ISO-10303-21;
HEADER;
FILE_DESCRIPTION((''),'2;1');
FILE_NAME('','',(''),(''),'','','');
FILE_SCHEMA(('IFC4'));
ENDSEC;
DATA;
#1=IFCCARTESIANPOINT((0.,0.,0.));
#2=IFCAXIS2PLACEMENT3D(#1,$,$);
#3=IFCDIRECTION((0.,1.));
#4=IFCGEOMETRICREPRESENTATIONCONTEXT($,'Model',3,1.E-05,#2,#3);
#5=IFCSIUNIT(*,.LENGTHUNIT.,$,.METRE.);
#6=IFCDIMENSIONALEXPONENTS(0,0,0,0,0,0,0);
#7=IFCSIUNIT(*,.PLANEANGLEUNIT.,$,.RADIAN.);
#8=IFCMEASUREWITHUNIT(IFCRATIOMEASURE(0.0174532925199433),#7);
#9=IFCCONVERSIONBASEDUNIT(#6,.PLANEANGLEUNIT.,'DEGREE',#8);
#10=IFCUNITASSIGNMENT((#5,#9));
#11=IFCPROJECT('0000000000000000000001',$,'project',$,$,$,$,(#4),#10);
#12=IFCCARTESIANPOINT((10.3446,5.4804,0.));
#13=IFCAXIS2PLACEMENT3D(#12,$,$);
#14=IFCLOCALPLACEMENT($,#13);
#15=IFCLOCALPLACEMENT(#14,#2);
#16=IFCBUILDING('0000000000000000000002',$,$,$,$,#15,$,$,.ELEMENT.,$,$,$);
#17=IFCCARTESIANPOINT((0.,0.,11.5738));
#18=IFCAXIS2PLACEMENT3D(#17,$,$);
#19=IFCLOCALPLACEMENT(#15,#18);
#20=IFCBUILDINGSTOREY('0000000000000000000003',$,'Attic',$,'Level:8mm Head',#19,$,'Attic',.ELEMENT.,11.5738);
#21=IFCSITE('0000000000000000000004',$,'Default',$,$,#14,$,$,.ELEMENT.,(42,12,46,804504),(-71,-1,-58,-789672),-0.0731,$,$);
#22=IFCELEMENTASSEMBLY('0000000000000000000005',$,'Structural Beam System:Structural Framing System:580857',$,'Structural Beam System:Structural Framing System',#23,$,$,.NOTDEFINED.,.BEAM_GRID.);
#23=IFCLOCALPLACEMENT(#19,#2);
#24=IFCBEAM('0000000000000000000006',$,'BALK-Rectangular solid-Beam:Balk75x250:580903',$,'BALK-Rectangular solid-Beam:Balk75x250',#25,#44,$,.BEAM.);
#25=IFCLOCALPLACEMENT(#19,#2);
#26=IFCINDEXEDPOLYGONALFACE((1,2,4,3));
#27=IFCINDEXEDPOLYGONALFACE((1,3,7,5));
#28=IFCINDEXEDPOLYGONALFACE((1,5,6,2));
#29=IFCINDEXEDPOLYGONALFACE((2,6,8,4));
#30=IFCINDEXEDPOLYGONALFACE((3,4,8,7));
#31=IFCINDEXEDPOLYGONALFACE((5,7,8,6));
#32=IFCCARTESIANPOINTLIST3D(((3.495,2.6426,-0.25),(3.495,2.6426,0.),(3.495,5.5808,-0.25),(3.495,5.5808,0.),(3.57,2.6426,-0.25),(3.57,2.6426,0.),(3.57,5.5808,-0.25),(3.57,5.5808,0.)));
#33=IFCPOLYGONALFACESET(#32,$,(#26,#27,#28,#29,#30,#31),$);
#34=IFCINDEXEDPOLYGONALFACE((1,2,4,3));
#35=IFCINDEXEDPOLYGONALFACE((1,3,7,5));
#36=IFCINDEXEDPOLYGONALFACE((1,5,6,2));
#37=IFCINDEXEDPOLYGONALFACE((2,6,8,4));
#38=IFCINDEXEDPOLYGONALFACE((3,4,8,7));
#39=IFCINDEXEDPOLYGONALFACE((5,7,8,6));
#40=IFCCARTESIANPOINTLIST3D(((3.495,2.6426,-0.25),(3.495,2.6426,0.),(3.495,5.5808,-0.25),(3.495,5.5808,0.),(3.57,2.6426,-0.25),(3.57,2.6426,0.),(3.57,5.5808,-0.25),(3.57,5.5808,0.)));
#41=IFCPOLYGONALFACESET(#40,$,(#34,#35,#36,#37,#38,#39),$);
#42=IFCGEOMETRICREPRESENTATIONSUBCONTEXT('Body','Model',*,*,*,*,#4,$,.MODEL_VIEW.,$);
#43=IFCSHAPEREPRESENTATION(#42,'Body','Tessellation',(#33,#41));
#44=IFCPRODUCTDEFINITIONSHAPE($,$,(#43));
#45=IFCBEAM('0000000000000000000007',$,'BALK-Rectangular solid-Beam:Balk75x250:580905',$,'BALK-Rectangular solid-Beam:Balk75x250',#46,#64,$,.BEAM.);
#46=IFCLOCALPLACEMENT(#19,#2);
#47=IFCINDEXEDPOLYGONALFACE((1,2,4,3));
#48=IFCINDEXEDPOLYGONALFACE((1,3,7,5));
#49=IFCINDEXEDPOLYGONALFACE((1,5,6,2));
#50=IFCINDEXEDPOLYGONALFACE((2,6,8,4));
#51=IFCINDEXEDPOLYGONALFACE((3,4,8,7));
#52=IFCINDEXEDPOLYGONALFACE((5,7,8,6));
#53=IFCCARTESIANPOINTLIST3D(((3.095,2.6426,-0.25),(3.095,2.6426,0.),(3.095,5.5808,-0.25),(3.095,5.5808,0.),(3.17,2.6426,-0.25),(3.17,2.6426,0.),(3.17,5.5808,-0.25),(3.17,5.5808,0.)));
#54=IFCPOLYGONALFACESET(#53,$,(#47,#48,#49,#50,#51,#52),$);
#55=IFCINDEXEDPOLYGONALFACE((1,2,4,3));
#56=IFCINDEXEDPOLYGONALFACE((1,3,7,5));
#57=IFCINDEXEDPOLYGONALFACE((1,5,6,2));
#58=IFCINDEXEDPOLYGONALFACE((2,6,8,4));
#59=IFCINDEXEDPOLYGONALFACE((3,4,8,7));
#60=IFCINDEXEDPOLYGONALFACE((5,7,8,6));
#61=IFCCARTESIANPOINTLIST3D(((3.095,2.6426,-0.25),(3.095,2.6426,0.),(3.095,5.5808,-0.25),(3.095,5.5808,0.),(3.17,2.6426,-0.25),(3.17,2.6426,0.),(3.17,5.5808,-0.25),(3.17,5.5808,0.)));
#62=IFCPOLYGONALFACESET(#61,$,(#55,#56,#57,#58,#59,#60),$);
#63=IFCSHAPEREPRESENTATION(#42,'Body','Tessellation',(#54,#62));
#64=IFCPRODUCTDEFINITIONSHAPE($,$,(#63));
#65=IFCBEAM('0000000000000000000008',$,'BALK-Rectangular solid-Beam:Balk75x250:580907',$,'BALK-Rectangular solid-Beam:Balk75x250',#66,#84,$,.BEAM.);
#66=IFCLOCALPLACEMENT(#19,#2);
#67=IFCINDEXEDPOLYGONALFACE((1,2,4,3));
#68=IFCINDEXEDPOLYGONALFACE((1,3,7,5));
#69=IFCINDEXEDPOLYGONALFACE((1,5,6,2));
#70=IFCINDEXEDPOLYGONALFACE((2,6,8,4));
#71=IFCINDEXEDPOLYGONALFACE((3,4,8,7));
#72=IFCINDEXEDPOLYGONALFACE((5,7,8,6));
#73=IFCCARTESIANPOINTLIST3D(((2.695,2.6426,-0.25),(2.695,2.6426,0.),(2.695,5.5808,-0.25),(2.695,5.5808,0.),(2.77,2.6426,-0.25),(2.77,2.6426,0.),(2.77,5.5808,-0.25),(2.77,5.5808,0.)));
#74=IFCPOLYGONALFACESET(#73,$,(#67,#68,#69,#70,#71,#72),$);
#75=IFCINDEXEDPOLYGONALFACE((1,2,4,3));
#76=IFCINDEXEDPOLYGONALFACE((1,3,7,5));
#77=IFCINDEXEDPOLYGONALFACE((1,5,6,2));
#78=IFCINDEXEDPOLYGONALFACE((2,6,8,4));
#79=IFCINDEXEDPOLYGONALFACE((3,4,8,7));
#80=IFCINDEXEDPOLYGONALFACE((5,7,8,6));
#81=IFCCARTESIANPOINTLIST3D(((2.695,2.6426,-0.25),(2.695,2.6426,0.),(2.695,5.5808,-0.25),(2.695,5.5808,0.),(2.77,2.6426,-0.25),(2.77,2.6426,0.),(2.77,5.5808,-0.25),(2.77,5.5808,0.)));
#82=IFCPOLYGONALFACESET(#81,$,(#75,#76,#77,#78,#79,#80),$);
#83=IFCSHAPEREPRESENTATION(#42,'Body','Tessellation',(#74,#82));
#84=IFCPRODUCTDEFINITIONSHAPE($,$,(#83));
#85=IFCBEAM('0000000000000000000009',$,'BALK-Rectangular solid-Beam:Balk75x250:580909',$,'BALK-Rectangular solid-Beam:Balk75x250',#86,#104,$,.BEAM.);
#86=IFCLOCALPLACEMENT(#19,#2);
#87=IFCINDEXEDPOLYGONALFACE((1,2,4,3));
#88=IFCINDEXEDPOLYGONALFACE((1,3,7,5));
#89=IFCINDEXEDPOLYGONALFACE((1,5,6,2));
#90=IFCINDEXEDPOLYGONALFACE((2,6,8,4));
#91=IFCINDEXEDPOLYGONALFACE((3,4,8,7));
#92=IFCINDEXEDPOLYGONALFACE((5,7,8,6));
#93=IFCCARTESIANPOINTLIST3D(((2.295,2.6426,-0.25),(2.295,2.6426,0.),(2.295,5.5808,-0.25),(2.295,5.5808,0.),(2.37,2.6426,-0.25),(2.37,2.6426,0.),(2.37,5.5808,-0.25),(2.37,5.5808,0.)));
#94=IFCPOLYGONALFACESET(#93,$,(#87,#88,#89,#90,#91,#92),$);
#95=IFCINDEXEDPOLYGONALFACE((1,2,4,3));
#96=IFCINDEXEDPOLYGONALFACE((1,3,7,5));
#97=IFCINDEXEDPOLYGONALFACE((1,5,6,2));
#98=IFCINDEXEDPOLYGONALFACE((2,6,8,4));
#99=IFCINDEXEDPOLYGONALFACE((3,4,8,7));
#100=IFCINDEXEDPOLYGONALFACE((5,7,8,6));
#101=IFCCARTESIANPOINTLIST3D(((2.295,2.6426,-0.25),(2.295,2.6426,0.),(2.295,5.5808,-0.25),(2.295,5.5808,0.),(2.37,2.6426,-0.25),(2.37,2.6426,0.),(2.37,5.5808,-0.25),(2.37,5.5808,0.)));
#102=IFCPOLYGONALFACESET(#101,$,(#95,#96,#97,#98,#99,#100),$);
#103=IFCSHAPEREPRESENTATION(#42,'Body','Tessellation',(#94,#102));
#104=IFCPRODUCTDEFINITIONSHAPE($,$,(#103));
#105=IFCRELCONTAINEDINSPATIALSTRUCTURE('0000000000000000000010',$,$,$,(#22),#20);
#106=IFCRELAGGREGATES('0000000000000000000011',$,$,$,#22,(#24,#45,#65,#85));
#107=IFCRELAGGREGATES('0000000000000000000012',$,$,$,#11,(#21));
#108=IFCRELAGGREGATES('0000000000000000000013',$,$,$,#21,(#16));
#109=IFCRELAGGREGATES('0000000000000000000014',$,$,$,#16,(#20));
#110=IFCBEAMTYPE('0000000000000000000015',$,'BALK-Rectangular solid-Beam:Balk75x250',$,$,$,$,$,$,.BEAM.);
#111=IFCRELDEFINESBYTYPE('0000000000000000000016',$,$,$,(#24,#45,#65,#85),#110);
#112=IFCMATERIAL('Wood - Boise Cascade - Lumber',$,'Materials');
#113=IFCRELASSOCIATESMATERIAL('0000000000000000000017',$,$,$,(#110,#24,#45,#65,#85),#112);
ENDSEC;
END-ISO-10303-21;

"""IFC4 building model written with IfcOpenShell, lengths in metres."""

from ifc_helpers import new_model, entity, si_unit, converted_unit, direction, frame, frame_2d, origin, origin_2d_with_axis, place, context, subcontext, project, spatial, rectangle, extrude, source, transform, mapped, material, material_profile, profile_set, profile_usage, type_object, type_shapes, element, aggregate, save


model = new_model("IFC4")

# Units and contexts
model_context = context("Model", 3, precision=1e-05, world=origin(), true_north=direction((0.0, 1.0)))
body_context = subcontext(model_context, "Body", "Model", "MODEL_VIEW")
ifc_project = project(units=[si_unit("LENGTHUNIT", "METRE"), converted_unit("PLANEANGLEUNIT", "DEGREE", entity("IfcRatioMeasure", 0.0174532925199433), si_unit("PLANEANGLEUNIT", "RADIAN"), dimensions=[0, 0, 0, 0, 0, 0, 0])], contexts=[model_context])

# Site, building, storey
site_placement = place(None, frame((10.3446, 5.4804, 0.0)))
site = spatial("IfcSite", under=ifc_project, at=site_placement, Name="Default", CompositionType="ELEMENT", RefLatitude=(42, 12, 46, 804504), RefLongitude=(-71, -1, -58, -789672), RefElevation=-0.0731)
building_placement = place(site_placement, origin())
building = spatial("IfcBuilding", under=site, at=building_placement, CompositionType="ELEMENT")
storey_placement = place(building_placement, frame((0.0, 0.0, 11.5738)))
storey = spatial("IfcBuildingStorey", under=building, at=storey_placement, Name="Attic", ObjectType="Level:8mm Head", LongName="Attic", CompositionType="ELEMENT", Elevation=11.5738)

# Shared definitions
ifc_material = material(Name="Wood - Boise Cascade - Lumber", Category="Materials")
ifc_material_profile = material_profile(ifc_material, rectangle(XDim=0.25, YDim=0.075, at=frame_2d((0.0, 0.0), x_axis=(1.0, 0.0))), Name="Balk75x250")
ifc_profile_set = profile_set([ifc_material_profile], Name="Balk75x250")

# Element assembly
assembly_1_placement = place(storey_placement, origin())
assembly_1 = element("IfcElementAssembly", 1, at=assembly_1_placement, inside=storey, Name="Structural Beam System:Structural Framing System:580857", ObjectType="Structural Beam System:Structural Framing System", AssemblyPlace="NOTDEFINED", PredefinedType="BEAM_GRID")

# Beams
beam_type_1 = type_object("IfcBeamType", Name="BALK-Rectangular solid-Beam:Balk75x250", PredefinedType="BEAM", material=ifc_profile_set)
shared_shape_1 = source(origin(), body_context, "Body", "SweptSolid", [
    extrude(rectangle(XDim=0.25, YDim=0.075, at=origin_2d_with_axis()), frame((-1.4566, 0.0, 0.0), z_axis=(1.0, 0.0, 0.0), x_axis=(0.0, 0.0, -1.0)), (0.0, 0.0, 1.0), 2.9382),
    extrude(rectangle(XDim=0.25, YDim=0.075, at=origin_2d_with_axis()), frame((-1.4566, 0.0, 0.0), z_axis=(1.0, 0.0, 0.0), x_axis=(0.0, 0.0, -1.0)), (0.0, 0.0, 1.0), 2.9382),
])
type_shapes(beam_type_1, [shared_shape_1])
ifc_profile_usage_1 = profile_usage(ifc_profile_set, cardinal=8)
beam_1_placement = place(assembly_1_placement, frame((3.5325, 4.1242, -0.125), z_axis=(0.0, 0.0, 1.0), x_axis=(0.0, -1.0, 0.0)))
beam_1 = element("IfcBeam", 2, at=beam_1_placement, type_object=beam_type_1, material=ifc_profile_usage_1, Name="BALK-Rectangular solid-Beam:Balk75x250:580903", ObjectType="BALK-Rectangular solid-Beam:Balk75x250", PredefinedType="BEAM", context=body_context, shape_type="MappedRepresentation", body=[
    mapped(shared_shape_1, transform((0.0, 0.0, 0.0), scale=1.0)),
])
ifc_profile_usage_2 = profile_usage(ifc_profile_set, cardinal=8)
beam_2_placement = place(assembly_1_placement, frame((3.1325, 4.1242, -0.125), z_axis=(0.0, 0.0, 1.0), x_axis=(0.0, -1.0, 0.0)))
beam_2 = element("IfcBeam", 3, at=beam_2_placement, type_object=beam_type_1, material=ifc_profile_usage_2, Name="BALK-Rectangular solid-Beam:Balk75x250:580905", ObjectType="BALK-Rectangular solid-Beam:Balk75x250", PredefinedType="BEAM", context=body_context, shape_type="MappedRepresentation", body=[
    mapped(shared_shape_1, transform((0.0, 0.0, 0.0), scale=1.0)),
])
ifc_profile_usage_3 = profile_usage(ifc_profile_set, cardinal=8)
beam_3_placement = place(assembly_1_placement, frame((2.7325, 4.1242, -0.125), z_axis=(0.0, 0.0, 1.0), x_axis=(0.0, -1.0, 0.0)))
beam_3 = element("IfcBeam", 4, at=beam_3_placement, type_object=beam_type_1, material=ifc_profile_usage_3, Name="BALK-Rectangular solid-Beam:Balk75x250:580907", ObjectType="BALK-Rectangular solid-Beam:Balk75x250", PredefinedType="BEAM", context=body_context, shape_type="MappedRepresentation", body=[
    mapped(shared_shape_1, transform((0.0, 0.0, 0.0), scale=1.0)),
])
ifc_profile_usage_4 = profile_usage(ifc_profile_set, cardinal=8)
beam_4_placement = place(assembly_1_placement, frame((2.3325, 4.1242, -0.125), z_axis=(0.0, 0.0, 1.0), x_axis=(0.0, -1.0, 0.0)))
beam_4 = element("IfcBeam", 5, at=beam_4_placement, type_object=beam_type_1, material=ifc_profile_usage_4, Name="BALK-Rectangular solid-Beam:Balk75x250:580909", ObjectType="BALK-Rectangular solid-Beam:Balk75x250", PredefinedType="BEAM", context=body_context, shape_type="MappedRepresentation", body=[
    mapped(shared_shape_1, transform((0.0, 0.0, 0.0), scale=1.0)),
])
aggregate(assembly_1, [beam_1, beam_2, beam_3, beam_4])

save(model, "model.ifc")
